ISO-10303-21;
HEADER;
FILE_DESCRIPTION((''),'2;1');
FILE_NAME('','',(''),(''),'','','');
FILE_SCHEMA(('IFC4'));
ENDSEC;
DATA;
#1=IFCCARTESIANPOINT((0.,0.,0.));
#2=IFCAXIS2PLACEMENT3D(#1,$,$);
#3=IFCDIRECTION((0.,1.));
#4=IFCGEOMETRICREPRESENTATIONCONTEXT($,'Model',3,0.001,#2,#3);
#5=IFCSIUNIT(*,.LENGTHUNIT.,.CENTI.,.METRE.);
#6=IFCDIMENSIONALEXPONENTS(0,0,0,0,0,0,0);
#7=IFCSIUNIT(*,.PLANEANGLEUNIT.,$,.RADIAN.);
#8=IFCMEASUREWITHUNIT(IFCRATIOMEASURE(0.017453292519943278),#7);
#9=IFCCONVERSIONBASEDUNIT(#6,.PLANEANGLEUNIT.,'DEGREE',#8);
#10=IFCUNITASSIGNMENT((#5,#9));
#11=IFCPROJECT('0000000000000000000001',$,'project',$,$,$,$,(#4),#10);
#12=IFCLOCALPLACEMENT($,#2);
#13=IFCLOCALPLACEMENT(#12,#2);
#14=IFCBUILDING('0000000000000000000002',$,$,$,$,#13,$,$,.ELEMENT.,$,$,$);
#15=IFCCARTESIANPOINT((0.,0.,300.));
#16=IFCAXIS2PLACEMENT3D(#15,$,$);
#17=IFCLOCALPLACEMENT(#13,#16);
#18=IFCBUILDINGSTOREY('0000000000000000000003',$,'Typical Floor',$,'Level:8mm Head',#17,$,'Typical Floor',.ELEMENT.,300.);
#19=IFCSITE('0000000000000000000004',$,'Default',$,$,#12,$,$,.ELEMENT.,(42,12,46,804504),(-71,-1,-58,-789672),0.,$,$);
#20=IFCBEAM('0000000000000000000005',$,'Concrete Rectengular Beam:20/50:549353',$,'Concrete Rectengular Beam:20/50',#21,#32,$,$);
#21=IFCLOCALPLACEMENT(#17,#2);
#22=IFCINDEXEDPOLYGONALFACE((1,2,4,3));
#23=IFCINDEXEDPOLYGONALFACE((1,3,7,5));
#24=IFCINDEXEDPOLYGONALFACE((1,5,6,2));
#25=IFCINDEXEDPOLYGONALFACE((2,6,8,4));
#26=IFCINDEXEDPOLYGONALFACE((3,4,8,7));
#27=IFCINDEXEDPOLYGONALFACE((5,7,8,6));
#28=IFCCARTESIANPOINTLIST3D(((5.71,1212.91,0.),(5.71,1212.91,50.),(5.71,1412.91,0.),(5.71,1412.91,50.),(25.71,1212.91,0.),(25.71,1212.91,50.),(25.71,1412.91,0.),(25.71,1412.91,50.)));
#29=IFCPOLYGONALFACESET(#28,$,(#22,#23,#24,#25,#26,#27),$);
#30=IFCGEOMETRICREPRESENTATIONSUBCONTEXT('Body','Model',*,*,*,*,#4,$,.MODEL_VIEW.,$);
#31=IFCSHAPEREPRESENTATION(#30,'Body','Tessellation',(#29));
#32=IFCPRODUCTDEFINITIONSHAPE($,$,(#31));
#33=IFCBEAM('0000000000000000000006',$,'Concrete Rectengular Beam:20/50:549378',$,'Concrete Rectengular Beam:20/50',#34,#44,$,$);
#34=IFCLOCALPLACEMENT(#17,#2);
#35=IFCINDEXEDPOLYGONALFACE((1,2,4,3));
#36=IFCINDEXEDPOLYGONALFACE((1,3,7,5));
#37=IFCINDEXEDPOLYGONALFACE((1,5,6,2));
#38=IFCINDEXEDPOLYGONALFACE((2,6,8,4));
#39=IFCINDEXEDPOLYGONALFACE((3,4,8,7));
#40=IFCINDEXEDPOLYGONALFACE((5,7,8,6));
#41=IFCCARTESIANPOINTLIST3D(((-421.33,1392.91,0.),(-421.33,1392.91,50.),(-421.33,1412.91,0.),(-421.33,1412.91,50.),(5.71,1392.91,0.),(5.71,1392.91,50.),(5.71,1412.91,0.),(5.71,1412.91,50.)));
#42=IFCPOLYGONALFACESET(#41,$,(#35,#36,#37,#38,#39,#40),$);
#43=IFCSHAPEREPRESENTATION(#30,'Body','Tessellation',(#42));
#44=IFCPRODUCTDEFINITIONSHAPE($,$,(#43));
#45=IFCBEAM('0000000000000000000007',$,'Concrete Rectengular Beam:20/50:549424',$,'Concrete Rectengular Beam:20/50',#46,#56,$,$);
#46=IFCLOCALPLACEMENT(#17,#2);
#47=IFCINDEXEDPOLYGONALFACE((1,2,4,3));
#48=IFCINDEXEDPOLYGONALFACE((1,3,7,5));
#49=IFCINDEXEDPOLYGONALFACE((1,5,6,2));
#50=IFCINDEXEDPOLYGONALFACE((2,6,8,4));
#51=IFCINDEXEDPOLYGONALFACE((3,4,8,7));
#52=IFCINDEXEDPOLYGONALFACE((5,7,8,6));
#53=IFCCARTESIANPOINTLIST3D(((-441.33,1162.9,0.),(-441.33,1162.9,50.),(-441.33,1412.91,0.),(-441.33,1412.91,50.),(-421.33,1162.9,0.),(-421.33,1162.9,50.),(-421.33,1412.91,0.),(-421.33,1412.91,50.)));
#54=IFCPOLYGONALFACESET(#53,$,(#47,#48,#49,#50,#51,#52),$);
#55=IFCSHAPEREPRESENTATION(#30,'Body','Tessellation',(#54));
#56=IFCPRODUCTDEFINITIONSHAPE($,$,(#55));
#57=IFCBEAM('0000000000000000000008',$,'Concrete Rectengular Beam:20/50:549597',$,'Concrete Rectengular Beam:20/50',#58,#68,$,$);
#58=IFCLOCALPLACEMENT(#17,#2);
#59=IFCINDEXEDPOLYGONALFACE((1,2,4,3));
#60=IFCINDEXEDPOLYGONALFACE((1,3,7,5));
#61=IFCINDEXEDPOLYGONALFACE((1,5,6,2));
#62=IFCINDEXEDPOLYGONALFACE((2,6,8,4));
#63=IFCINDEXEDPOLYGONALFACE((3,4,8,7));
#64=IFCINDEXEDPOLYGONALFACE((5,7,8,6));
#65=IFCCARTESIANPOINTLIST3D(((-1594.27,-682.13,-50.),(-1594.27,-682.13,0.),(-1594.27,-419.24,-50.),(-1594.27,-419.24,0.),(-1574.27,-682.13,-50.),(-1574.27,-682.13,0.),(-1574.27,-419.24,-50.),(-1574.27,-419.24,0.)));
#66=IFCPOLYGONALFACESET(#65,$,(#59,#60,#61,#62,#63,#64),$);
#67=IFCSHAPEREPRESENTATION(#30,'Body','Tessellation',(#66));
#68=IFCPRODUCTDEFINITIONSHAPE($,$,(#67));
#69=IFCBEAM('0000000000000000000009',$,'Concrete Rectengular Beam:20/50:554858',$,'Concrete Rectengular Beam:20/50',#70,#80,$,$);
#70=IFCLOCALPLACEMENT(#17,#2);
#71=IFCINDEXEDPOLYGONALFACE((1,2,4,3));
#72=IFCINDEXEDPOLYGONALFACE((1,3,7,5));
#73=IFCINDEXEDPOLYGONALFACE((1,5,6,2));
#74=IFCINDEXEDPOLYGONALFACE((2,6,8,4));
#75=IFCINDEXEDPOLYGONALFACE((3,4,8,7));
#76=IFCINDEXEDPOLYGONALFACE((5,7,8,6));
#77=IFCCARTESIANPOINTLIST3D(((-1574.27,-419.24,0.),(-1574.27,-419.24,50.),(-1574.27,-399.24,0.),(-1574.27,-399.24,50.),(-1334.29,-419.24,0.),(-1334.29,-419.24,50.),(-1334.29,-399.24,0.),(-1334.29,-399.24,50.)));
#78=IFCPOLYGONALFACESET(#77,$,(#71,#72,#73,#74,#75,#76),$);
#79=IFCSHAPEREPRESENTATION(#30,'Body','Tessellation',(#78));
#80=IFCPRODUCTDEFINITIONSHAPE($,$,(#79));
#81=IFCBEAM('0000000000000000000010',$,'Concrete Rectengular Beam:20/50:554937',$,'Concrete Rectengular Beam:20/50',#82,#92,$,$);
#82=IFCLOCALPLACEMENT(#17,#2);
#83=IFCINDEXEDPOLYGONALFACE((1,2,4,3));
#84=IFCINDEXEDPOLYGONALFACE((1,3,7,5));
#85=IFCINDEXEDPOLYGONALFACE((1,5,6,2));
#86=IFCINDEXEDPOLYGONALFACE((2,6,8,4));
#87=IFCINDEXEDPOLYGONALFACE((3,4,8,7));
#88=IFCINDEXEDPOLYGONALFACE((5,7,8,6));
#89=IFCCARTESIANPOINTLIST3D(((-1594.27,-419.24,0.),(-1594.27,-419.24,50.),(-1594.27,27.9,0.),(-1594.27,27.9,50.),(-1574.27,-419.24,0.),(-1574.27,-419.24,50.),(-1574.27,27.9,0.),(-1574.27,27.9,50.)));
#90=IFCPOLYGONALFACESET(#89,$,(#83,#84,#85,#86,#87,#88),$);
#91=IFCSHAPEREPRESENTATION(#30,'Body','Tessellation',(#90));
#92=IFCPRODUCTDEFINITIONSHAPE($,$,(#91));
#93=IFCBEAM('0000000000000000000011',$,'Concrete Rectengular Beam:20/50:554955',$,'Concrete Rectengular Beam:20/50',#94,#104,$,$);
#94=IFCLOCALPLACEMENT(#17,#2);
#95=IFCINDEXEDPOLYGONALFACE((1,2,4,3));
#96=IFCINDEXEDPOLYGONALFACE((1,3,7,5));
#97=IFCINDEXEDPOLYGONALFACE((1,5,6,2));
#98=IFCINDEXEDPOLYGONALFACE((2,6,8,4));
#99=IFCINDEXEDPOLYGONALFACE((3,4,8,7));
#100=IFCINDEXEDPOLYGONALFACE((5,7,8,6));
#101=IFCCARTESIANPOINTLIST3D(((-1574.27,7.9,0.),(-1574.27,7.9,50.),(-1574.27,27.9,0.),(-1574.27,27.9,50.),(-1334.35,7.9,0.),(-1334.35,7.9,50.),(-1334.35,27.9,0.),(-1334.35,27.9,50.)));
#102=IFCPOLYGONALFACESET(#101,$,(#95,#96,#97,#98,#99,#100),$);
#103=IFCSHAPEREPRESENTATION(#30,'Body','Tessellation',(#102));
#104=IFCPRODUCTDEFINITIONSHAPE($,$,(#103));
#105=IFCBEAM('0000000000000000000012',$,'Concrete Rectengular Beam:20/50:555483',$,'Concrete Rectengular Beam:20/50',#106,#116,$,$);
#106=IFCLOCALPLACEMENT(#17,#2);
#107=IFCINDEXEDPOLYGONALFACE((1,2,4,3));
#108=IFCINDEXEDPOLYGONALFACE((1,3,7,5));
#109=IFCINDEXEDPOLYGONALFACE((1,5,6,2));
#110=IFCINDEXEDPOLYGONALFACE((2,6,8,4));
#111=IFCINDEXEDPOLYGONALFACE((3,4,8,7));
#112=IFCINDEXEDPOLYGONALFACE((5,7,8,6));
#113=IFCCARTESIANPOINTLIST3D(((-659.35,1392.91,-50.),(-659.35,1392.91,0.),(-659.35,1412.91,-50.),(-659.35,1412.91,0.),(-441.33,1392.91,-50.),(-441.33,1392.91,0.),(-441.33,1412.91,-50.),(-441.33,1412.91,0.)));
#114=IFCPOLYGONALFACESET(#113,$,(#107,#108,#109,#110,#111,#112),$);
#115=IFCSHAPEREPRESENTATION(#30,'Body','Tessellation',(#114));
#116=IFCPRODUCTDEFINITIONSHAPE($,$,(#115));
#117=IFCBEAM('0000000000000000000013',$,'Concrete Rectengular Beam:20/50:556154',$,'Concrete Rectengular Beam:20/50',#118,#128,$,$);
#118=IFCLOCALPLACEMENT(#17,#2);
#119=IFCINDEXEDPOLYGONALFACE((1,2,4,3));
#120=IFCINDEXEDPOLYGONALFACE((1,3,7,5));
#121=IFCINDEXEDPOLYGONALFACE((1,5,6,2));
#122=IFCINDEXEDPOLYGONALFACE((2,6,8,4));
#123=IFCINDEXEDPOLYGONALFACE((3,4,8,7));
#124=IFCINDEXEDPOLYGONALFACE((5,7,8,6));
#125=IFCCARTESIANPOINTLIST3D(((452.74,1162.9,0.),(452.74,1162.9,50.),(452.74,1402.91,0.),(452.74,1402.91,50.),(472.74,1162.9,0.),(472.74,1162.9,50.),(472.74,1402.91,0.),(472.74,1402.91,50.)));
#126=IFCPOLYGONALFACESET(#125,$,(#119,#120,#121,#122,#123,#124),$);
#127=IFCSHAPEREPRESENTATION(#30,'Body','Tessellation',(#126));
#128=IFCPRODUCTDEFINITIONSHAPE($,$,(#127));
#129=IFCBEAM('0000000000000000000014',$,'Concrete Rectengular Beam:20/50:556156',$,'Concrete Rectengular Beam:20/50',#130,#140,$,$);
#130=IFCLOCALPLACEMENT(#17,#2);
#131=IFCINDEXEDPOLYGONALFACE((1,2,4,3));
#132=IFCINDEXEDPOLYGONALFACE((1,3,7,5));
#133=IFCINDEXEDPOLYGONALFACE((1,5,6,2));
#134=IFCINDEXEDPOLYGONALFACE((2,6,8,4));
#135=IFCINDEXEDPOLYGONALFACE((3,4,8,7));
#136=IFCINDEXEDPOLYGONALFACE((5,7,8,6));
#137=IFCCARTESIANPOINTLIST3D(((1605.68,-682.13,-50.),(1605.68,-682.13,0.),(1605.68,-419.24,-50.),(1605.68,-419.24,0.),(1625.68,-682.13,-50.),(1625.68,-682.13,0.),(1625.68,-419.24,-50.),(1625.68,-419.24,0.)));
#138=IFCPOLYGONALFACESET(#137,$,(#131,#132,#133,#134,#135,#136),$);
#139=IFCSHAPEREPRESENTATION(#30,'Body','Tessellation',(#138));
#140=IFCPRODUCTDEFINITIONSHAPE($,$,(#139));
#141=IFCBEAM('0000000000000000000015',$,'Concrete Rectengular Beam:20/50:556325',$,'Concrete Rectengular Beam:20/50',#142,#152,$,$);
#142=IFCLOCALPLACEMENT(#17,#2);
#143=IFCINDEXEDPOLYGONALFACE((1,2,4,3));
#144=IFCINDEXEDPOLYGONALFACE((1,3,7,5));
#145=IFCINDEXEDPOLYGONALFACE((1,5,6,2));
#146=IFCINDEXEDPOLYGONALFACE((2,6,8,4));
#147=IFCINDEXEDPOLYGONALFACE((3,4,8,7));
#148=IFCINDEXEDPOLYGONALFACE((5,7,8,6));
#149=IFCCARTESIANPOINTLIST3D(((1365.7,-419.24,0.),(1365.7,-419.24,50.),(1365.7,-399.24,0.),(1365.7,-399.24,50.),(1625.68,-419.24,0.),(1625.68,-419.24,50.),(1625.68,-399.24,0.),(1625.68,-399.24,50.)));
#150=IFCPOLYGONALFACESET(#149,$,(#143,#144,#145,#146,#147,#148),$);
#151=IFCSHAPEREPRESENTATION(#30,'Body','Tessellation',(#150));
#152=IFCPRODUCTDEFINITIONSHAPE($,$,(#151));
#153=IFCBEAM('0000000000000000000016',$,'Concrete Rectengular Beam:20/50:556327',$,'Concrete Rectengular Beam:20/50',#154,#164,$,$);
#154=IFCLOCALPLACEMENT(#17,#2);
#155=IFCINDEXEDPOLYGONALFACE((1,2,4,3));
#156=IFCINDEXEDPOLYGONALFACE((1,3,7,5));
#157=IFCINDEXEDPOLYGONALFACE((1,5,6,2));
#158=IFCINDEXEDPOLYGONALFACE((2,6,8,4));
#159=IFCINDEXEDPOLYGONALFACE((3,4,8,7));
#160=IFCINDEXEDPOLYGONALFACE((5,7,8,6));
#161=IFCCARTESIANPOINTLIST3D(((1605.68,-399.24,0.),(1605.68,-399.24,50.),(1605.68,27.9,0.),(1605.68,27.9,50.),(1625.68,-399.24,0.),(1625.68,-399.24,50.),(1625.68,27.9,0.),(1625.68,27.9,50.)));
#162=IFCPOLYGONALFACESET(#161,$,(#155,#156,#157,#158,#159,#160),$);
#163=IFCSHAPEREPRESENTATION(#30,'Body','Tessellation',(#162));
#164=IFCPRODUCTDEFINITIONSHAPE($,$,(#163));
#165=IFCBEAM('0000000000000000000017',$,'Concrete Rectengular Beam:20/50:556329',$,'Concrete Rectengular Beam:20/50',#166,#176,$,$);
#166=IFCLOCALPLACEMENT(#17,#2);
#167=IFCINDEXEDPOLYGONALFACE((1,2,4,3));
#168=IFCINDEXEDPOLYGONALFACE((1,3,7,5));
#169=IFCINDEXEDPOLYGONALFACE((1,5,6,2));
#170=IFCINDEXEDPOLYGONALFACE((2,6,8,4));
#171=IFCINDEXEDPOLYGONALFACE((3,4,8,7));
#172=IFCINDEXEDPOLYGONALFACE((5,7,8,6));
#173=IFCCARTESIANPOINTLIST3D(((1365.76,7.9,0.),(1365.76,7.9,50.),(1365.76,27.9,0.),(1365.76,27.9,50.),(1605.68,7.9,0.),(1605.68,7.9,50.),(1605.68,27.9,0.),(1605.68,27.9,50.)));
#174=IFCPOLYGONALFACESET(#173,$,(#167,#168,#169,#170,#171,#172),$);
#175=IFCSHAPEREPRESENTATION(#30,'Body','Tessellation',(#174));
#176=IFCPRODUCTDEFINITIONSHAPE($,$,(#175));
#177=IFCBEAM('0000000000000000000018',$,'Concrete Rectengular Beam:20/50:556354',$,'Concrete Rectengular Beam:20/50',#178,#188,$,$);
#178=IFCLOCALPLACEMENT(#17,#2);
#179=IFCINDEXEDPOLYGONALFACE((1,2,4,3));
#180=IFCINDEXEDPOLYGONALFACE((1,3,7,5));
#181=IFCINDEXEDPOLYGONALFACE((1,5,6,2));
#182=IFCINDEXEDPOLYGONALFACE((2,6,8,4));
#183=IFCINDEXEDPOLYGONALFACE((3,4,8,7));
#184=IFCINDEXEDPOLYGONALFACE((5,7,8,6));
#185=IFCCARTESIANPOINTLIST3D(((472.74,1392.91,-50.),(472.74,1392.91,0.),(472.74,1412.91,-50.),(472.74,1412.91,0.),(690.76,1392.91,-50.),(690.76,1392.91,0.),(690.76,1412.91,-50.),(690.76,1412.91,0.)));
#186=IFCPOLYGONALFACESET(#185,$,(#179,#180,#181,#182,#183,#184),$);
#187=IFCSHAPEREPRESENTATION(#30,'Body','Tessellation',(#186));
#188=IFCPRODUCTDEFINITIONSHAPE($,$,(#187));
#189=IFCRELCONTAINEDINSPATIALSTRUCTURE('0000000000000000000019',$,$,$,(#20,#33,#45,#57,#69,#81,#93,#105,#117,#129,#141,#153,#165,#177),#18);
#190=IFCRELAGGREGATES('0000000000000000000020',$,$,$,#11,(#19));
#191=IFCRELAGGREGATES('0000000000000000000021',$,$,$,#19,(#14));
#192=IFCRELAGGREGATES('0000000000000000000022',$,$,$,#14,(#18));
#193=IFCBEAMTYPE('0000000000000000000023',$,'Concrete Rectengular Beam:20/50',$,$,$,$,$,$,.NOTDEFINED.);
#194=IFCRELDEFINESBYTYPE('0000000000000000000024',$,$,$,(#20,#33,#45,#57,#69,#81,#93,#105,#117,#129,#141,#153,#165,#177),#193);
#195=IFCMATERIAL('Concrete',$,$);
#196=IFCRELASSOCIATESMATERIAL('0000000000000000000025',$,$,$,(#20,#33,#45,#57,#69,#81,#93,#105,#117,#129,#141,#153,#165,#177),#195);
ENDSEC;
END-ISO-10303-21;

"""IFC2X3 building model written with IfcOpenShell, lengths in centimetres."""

from ifc_helpers import new_model, entity, si_unit, converted_unit, direction, frame, frame_2d, origin, origin_2d_with_axis, place, context, subcontext, project, spatial, rectangle, extrude, material, type_object, element, save


model = new_model("IFC2X3")

# Units and contexts
model_context = context("Model", 3, precision=0.001, world=origin(), true_north=direction((0.0, 1.0)))
body_context = subcontext(model_context, "Body", "Model", "MODEL_VIEW")
ifc_project = project(units=[si_unit("LENGTHUNIT", "METRE", prefix="CENTI"), converted_unit("PLANEANGLEUNIT", "DEGREE", entity("IfcRatioMeasure", 0.017453292519943278), si_unit("PLANEANGLEUNIT", "RADIAN"), dimensions=[0, 0, 0, 0, 0, 0, 0])], contexts=[model_context])

# Site, building, storey
site_placement = place(None, origin())
site = spatial("IfcSite", under=ifc_project, at=site_placement, Name="Default", CompositionType="ELEMENT", RefLatitude=(42, 12, 46, 804504), RefLongitude=(-71, -1, -58, -789672), RefElevation=0.0)
building_placement = place(site_placement, origin())
building = spatial("IfcBuilding", under=site, at=building_placement, CompositionType="ELEMENT")
storey_placement = place(building_placement, frame((0.0, 0.0, 300.0)))
storey = spatial("IfcBuildingStorey", under=building, at=storey_placement, Name="Typical Floor", ObjectType="Level:8mm Head", LongName="Typical Floor", CompositionType="ELEMENT", Elevation=300.0)

# Beams
ifc_material = material(Name="Concrete")
beam_type_1 = type_object("IfcBeamType", Name="Concrete Rectengular Beam:20/50", PredefinedType="NOTDEFINED")
beam_1_placement = place(storey_placement, frame((15.71, 1212.91, 0.0), z_axis=(0.0, 0.0, 1.0), x_axis=(0.0, 1.0, 0.0)))
element("IfcBeam", 1, at=beam_1_placement, inside=storey, type_object=beam_type_1, material=ifc_material, Name="Concrete Rectengular Beam:20/50:549353", ObjectType="Concrete Rectengular Beam:20/50", context=body_context, shape_type="SweptSolid", body=[
    extrude(rectangle(XDim=50.0, YDim=20.0, at=origin_2d_with_axis()), frame((0.0, 0.0, 25.0), z_axis=(1.0, 0.0, 0.0), x_axis=(0.0, 0.0, -1.0)), (0.0, 0.0, 1.0), 200.0),
])
beam_2_placement = place(storey_placement, frame((15.71, 1402.91, 0.0), z_axis=(0.0, 0.0, 1.0), x_axis=(-1.0, 0.0, 0.0)))
element("IfcBeam", 2, at=beam_2_placement, inside=storey, type_object=beam_type_1, material=ifc_material, Name="Concrete Rectengular Beam:20/50:549378", ObjectType="Concrete Rectengular Beam:20/50", context=body_context, shape_type="SweptSolid", body=[
    extrude(rectangle(XDim=50.0, YDim=20.0, at=frame_2d((0.0, 0.0), x_axis=(1.0, 0.0))), frame((10.0, 0.0, 25.0), z_axis=(1.0, 0.0, 0.0), x_axis=(0.0, 0.0, -1.0)), (0.0, 0.0, 1.0), 427.04),
])
beam_3_placement = place(storey_placement, frame((-431.33, 1412.91, 0.0), z_axis=(0.0, 0.0, 1.0), x_axis=(0.0, -1.0, 0.0)))
element("IfcBeam", 3, at=beam_3_placement, inside=storey, type_object=beam_type_1, material=ifc_material, Name="Concrete Rectengular Beam:20/50:549424", ObjectType="Concrete Rectengular Beam:20/50", context=body_context, shape_type="SweptSolid", body=[
    extrude(rectangle(XDim=50.0, YDim=20.0, at=frame_2d((0.0, 0.0), x_axis=(1.0, 0.0))), frame((0.0, 0.0, 25.0), z_axis=(1.0, 0.0, 0.0), x_axis=(0.0, 0.0, -1.0)), (0.0, 0.0, 1.0), 250.01),
])
beam_4_placement = place(storey_placement, frame((-1584.27, -702.13, 0.0), z_axis=(0.0, 0.0, 1.0), x_axis=(0.0, 1.0, 0.0)))
element("IfcBeam", 4, at=beam_4_placement, inside=storey, type_object=beam_type_1, material=ifc_material, Name="Concrete Rectengular Beam:20/50:549597", ObjectType="Concrete Rectengular Beam:20/50", context=body_context, shape_type="SweptSolid", body=[
    extrude(rectangle(XDim=50.0, YDim=20.0, at=frame_2d((0.0, 0.0), x_axis=(1.0, 0.0))), frame((20.0, 0.0, -25.0), z_axis=(1.0, 0.0, 0.0), x_axis=(0.0, 0.0, -1.0)), (0.0, 0.0, 1.0), 262.89),
])
beam_5_placement = place(storey_placement, frame((-1574.27, -409.24, 0.0)))
element("IfcBeam", 5, at=beam_5_placement, inside=storey, type_object=beam_type_1, material=ifc_material, Name="Concrete Rectengular Beam:20/50:554858", ObjectType="Concrete Rectengular Beam:20/50", context=body_context, shape_type="SweptSolid", body=[
    extrude(rectangle(XDim=50.0, YDim=20.0, at=frame_2d((0.0, 0.0), x_axis=(1.0, 0.0))), frame((0.0, 0.0, 25.0), z_axis=(1.0, 0.0, 0.0), x_axis=(0.0, 0.0, -1.0)), (0.0, 0.0, 1.0), 239.98),
])
beam_6_placement = place(storey_placement, frame((-1584.27, -419.24, 0.0), z_axis=(0.0, 0.0, 1.0), x_axis=(0.0, 1.0, 0.0)))
element("IfcBeam", 6, at=beam_6_placement, inside=storey, type_object=beam_type_1, material=ifc_material, Name="Concrete Rectengular Beam:20/50:554937", ObjectType="Concrete Rectengular Beam:20/50", context=body_context, shape_type="SweptSolid", body=[
    extrude(rectangle(XDim=50.0, YDim=20.0, at=frame_2d((0.0, 0.0), x_axis=(1.0, 0.0))), frame((0.0, 0.0, 25.0), z_axis=(1.0, 0.0, 0.0), x_axis=(0.0, 0.0, -1.0)), (0.0, 0.0, 1.0), 447.14),
])
beam_7_placement = place(storey_placement, frame((-1584.27, 17.9, 0.0)))
element("IfcBeam", 7, at=beam_7_placement, inside=storey, type_object=beam_type_1, material=ifc_material, Name="Concrete Rectengular Beam:20/50:554955", ObjectType="Concrete Rectengular Beam:20/50", context=body_context, shape_type="SweptSolid", body=[
    extrude(rectangle(XDim=50.0, YDim=20.0, at=frame_2d((0.0, 0.0), x_axis=(1.0, 0.0))), frame((10.0, 0.0, 25.0), z_axis=(1.0, 0.0, 0.0), x_axis=(0.0, 0.0, -1.0)), (0.0, 0.0, 1.0), 239.92),
])
beam_8_placement = place(storey_placement, frame((-441.33, 1402.91, 0.0), z_axis=(0.0, 0.0, 1.0), x_axis=(-1.0, 0.0, 0.0)))
element("IfcBeam", 8, at=beam_8_placement, inside=storey, type_object=beam_type_1, material=ifc_material, Name="Concrete Rectengular Beam:20/50:555483", ObjectType="Concrete Rectengular Beam:20/50", context=body_context, shape_type="SweptSolid", body=[
    extrude(rectangle(XDim=50.0, YDim=20.0, at=frame_2d((0.0, 0.0), x_axis=(1.0, 0.0))), frame((0.0, 0.0, -25.0), z_axis=(1.0, 0.0, 0.0), x_axis=(0.0, 0.0, -1.0)), (0.0, 0.0, 1.0), 218.02),
])
beam_9_placement = place(storey_placement, frame((462.74, 1402.91, 0.0), z_axis=(0.0, 0.0, 1.0), x_axis=(0.0, -1.0, 0.0)))
element("IfcBeam", 9, at=beam_9_placement, inside=storey, type_object=beam_type_1, material=ifc_material, Name="Concrete Rectengular Beam:20/50:556154", ObjectType="Concrete Rectengular Beam:20/50", context=body_context, shape_type="SweptSolid", body=[
    extrude(rectangle(XDim=50.0, YDim=20.0, at=frame_2d((0.0, 0.0), x_axis=(1.0, 0.0))), frame((0.0, 0.0, 25.0), z_axis=(1.0, 0.0, 0.0), x_axis=(0.0, 0.0, -1.0)), (0.0, 0.0, 1.0), 240.01),
])
beam_10_placement = place(storey_placement, frame((1615.68, -702.13, 0.0), z_axis=(0.0, 0.0, 1.0), x_axis=(0.0, 1.0, 0.0)))
element("IfcBeam", 10, at=beam_10_placement, inside=storey, type_object=beam_type_1, material=ifc_material, Name="Concrete Rectengular Beam:20/50:556156", ObjectType="Concrete Rectengular Beam:20/50", context=body_context, shape_type="SweptSolid", body=[
    extrude(rectangle(XDim=50.0, YDim=20.0, at=origin_2d_with_axis()), frame((20.0, 0.0, -25.0), z_axis=(1.0, 0.0, 0.0), x_axis=(0.0, 0.0, -1.0)), (0.0, 0.0, 1.0), 262.89),
])
beam_11_placement = place(storey_placement, frame((1615.68, -409.24, 0.0), z_axis=(0.0, 0.0, 1.0), x_axis=(-1.0, 0.0, 0.0)))
element("IfcBeam", 11, at=beam_11_placement, inside=storey, type_object=beam_type_1, material=ifc_material, Name="Concrete Rectengular Beam:20/50:556325", ObjectType="Concrete Rectengular Beam:20/50", context=body_context, shape_type="SweptSolid", body=[
    extrude(rectangle(XDim=50.0, YDim=20.0, at=frame_2d((0.0, 0.0), x_axis=(1.0, 0.0))), frame((-10.0, 0.0, 25.0), z_axis=(1.0, 0.0, 0.0), x_axis=(0.0, 0.0, -1.0)), (0.0, 0.0, 1.0), 259.98),
])
beam_12_placement = place(storey_placement, frame((1615.68, -409.24, 0.0), z_axis=(0.0, 0.0, 1.0), x_axis=(0.0, 1.0, 0.0)))
element("IfcBeam", 12, at=beam_12_placement, inside=storey, type_object=beam_type_1, material=ifc_material, Name="Concrete Rectengular Beam:20/50:556327", ObjectType="Concrete Rectengular Beam:20/50", context=body_context, shape_type="SweptSolid", body=[
    extrude(rectangle(XDim=50.0, YDim=20.0, at=frame_2d((0.0, 0.0), x_axis=(1.0, 0.0))), frame((10.0, 0.0, 25.0), z_axis=(1.0, 0.0, 0.0), x_axis=(0.0, 0.0, -1.0)), (0.0, 0.0, 1.0), 427.14),
])
beam_13_placement = place(storey_placement, frame((1615.68, 17.9, 0.0), z_axis=(0.0, 0.0, 1.0), x_axis=(-1.0, 0.0, 0.0)))
element("IfcBeam", 13, at=beam_13_placement, inside=storey, type_object=beam_type_1, material=ifc_material, Name="Concrete Rectengular Beam:20/50:556329", ObjectType="Concrete Rectengular Beam:20/50", context=body_context, shape_type="SweptSolid", body=[
    extrude(rectangle(XDim=50.0, YDim=20.0, at=frame_2d((0.0, 0.0), x_axis=(1.0, 0.0))), frame((10.0, 0.0, 25.0), z_axis=(1.0, 0.0, 0.0), x_axis=(0.0, 0.0, -1.0)), (0.0, 0.0, 1.0), 239.92),
])
beam_14_placement = place(storey_placement, frame((472.74, 1402.91, 0.0)))
element("IfcBeam", 14, at=beam_14_placement, inside=storey, type_object=beam_type_1, material=ifc_material, Name="Concrete Rectengular Beam:20/50:556354", ObjectType="Concrete Rectengular Beam:20/50", context=body_context, shape_type="SweptSolid", body=[
    extrude(rectangle(XDim=50.0, YDim=20.0, at=frame_2d((0.0, 0.0), x_axis=(1.0, 0.0))), frame((0.0, 0.0, -25.0), z_axis=(1.0, 0.0, 0.0), x_axis=(0.0, 0.0, -1.0)), (0.0, 0.0, 1.0), 218.02),
])

save(model, "model.ifc")
